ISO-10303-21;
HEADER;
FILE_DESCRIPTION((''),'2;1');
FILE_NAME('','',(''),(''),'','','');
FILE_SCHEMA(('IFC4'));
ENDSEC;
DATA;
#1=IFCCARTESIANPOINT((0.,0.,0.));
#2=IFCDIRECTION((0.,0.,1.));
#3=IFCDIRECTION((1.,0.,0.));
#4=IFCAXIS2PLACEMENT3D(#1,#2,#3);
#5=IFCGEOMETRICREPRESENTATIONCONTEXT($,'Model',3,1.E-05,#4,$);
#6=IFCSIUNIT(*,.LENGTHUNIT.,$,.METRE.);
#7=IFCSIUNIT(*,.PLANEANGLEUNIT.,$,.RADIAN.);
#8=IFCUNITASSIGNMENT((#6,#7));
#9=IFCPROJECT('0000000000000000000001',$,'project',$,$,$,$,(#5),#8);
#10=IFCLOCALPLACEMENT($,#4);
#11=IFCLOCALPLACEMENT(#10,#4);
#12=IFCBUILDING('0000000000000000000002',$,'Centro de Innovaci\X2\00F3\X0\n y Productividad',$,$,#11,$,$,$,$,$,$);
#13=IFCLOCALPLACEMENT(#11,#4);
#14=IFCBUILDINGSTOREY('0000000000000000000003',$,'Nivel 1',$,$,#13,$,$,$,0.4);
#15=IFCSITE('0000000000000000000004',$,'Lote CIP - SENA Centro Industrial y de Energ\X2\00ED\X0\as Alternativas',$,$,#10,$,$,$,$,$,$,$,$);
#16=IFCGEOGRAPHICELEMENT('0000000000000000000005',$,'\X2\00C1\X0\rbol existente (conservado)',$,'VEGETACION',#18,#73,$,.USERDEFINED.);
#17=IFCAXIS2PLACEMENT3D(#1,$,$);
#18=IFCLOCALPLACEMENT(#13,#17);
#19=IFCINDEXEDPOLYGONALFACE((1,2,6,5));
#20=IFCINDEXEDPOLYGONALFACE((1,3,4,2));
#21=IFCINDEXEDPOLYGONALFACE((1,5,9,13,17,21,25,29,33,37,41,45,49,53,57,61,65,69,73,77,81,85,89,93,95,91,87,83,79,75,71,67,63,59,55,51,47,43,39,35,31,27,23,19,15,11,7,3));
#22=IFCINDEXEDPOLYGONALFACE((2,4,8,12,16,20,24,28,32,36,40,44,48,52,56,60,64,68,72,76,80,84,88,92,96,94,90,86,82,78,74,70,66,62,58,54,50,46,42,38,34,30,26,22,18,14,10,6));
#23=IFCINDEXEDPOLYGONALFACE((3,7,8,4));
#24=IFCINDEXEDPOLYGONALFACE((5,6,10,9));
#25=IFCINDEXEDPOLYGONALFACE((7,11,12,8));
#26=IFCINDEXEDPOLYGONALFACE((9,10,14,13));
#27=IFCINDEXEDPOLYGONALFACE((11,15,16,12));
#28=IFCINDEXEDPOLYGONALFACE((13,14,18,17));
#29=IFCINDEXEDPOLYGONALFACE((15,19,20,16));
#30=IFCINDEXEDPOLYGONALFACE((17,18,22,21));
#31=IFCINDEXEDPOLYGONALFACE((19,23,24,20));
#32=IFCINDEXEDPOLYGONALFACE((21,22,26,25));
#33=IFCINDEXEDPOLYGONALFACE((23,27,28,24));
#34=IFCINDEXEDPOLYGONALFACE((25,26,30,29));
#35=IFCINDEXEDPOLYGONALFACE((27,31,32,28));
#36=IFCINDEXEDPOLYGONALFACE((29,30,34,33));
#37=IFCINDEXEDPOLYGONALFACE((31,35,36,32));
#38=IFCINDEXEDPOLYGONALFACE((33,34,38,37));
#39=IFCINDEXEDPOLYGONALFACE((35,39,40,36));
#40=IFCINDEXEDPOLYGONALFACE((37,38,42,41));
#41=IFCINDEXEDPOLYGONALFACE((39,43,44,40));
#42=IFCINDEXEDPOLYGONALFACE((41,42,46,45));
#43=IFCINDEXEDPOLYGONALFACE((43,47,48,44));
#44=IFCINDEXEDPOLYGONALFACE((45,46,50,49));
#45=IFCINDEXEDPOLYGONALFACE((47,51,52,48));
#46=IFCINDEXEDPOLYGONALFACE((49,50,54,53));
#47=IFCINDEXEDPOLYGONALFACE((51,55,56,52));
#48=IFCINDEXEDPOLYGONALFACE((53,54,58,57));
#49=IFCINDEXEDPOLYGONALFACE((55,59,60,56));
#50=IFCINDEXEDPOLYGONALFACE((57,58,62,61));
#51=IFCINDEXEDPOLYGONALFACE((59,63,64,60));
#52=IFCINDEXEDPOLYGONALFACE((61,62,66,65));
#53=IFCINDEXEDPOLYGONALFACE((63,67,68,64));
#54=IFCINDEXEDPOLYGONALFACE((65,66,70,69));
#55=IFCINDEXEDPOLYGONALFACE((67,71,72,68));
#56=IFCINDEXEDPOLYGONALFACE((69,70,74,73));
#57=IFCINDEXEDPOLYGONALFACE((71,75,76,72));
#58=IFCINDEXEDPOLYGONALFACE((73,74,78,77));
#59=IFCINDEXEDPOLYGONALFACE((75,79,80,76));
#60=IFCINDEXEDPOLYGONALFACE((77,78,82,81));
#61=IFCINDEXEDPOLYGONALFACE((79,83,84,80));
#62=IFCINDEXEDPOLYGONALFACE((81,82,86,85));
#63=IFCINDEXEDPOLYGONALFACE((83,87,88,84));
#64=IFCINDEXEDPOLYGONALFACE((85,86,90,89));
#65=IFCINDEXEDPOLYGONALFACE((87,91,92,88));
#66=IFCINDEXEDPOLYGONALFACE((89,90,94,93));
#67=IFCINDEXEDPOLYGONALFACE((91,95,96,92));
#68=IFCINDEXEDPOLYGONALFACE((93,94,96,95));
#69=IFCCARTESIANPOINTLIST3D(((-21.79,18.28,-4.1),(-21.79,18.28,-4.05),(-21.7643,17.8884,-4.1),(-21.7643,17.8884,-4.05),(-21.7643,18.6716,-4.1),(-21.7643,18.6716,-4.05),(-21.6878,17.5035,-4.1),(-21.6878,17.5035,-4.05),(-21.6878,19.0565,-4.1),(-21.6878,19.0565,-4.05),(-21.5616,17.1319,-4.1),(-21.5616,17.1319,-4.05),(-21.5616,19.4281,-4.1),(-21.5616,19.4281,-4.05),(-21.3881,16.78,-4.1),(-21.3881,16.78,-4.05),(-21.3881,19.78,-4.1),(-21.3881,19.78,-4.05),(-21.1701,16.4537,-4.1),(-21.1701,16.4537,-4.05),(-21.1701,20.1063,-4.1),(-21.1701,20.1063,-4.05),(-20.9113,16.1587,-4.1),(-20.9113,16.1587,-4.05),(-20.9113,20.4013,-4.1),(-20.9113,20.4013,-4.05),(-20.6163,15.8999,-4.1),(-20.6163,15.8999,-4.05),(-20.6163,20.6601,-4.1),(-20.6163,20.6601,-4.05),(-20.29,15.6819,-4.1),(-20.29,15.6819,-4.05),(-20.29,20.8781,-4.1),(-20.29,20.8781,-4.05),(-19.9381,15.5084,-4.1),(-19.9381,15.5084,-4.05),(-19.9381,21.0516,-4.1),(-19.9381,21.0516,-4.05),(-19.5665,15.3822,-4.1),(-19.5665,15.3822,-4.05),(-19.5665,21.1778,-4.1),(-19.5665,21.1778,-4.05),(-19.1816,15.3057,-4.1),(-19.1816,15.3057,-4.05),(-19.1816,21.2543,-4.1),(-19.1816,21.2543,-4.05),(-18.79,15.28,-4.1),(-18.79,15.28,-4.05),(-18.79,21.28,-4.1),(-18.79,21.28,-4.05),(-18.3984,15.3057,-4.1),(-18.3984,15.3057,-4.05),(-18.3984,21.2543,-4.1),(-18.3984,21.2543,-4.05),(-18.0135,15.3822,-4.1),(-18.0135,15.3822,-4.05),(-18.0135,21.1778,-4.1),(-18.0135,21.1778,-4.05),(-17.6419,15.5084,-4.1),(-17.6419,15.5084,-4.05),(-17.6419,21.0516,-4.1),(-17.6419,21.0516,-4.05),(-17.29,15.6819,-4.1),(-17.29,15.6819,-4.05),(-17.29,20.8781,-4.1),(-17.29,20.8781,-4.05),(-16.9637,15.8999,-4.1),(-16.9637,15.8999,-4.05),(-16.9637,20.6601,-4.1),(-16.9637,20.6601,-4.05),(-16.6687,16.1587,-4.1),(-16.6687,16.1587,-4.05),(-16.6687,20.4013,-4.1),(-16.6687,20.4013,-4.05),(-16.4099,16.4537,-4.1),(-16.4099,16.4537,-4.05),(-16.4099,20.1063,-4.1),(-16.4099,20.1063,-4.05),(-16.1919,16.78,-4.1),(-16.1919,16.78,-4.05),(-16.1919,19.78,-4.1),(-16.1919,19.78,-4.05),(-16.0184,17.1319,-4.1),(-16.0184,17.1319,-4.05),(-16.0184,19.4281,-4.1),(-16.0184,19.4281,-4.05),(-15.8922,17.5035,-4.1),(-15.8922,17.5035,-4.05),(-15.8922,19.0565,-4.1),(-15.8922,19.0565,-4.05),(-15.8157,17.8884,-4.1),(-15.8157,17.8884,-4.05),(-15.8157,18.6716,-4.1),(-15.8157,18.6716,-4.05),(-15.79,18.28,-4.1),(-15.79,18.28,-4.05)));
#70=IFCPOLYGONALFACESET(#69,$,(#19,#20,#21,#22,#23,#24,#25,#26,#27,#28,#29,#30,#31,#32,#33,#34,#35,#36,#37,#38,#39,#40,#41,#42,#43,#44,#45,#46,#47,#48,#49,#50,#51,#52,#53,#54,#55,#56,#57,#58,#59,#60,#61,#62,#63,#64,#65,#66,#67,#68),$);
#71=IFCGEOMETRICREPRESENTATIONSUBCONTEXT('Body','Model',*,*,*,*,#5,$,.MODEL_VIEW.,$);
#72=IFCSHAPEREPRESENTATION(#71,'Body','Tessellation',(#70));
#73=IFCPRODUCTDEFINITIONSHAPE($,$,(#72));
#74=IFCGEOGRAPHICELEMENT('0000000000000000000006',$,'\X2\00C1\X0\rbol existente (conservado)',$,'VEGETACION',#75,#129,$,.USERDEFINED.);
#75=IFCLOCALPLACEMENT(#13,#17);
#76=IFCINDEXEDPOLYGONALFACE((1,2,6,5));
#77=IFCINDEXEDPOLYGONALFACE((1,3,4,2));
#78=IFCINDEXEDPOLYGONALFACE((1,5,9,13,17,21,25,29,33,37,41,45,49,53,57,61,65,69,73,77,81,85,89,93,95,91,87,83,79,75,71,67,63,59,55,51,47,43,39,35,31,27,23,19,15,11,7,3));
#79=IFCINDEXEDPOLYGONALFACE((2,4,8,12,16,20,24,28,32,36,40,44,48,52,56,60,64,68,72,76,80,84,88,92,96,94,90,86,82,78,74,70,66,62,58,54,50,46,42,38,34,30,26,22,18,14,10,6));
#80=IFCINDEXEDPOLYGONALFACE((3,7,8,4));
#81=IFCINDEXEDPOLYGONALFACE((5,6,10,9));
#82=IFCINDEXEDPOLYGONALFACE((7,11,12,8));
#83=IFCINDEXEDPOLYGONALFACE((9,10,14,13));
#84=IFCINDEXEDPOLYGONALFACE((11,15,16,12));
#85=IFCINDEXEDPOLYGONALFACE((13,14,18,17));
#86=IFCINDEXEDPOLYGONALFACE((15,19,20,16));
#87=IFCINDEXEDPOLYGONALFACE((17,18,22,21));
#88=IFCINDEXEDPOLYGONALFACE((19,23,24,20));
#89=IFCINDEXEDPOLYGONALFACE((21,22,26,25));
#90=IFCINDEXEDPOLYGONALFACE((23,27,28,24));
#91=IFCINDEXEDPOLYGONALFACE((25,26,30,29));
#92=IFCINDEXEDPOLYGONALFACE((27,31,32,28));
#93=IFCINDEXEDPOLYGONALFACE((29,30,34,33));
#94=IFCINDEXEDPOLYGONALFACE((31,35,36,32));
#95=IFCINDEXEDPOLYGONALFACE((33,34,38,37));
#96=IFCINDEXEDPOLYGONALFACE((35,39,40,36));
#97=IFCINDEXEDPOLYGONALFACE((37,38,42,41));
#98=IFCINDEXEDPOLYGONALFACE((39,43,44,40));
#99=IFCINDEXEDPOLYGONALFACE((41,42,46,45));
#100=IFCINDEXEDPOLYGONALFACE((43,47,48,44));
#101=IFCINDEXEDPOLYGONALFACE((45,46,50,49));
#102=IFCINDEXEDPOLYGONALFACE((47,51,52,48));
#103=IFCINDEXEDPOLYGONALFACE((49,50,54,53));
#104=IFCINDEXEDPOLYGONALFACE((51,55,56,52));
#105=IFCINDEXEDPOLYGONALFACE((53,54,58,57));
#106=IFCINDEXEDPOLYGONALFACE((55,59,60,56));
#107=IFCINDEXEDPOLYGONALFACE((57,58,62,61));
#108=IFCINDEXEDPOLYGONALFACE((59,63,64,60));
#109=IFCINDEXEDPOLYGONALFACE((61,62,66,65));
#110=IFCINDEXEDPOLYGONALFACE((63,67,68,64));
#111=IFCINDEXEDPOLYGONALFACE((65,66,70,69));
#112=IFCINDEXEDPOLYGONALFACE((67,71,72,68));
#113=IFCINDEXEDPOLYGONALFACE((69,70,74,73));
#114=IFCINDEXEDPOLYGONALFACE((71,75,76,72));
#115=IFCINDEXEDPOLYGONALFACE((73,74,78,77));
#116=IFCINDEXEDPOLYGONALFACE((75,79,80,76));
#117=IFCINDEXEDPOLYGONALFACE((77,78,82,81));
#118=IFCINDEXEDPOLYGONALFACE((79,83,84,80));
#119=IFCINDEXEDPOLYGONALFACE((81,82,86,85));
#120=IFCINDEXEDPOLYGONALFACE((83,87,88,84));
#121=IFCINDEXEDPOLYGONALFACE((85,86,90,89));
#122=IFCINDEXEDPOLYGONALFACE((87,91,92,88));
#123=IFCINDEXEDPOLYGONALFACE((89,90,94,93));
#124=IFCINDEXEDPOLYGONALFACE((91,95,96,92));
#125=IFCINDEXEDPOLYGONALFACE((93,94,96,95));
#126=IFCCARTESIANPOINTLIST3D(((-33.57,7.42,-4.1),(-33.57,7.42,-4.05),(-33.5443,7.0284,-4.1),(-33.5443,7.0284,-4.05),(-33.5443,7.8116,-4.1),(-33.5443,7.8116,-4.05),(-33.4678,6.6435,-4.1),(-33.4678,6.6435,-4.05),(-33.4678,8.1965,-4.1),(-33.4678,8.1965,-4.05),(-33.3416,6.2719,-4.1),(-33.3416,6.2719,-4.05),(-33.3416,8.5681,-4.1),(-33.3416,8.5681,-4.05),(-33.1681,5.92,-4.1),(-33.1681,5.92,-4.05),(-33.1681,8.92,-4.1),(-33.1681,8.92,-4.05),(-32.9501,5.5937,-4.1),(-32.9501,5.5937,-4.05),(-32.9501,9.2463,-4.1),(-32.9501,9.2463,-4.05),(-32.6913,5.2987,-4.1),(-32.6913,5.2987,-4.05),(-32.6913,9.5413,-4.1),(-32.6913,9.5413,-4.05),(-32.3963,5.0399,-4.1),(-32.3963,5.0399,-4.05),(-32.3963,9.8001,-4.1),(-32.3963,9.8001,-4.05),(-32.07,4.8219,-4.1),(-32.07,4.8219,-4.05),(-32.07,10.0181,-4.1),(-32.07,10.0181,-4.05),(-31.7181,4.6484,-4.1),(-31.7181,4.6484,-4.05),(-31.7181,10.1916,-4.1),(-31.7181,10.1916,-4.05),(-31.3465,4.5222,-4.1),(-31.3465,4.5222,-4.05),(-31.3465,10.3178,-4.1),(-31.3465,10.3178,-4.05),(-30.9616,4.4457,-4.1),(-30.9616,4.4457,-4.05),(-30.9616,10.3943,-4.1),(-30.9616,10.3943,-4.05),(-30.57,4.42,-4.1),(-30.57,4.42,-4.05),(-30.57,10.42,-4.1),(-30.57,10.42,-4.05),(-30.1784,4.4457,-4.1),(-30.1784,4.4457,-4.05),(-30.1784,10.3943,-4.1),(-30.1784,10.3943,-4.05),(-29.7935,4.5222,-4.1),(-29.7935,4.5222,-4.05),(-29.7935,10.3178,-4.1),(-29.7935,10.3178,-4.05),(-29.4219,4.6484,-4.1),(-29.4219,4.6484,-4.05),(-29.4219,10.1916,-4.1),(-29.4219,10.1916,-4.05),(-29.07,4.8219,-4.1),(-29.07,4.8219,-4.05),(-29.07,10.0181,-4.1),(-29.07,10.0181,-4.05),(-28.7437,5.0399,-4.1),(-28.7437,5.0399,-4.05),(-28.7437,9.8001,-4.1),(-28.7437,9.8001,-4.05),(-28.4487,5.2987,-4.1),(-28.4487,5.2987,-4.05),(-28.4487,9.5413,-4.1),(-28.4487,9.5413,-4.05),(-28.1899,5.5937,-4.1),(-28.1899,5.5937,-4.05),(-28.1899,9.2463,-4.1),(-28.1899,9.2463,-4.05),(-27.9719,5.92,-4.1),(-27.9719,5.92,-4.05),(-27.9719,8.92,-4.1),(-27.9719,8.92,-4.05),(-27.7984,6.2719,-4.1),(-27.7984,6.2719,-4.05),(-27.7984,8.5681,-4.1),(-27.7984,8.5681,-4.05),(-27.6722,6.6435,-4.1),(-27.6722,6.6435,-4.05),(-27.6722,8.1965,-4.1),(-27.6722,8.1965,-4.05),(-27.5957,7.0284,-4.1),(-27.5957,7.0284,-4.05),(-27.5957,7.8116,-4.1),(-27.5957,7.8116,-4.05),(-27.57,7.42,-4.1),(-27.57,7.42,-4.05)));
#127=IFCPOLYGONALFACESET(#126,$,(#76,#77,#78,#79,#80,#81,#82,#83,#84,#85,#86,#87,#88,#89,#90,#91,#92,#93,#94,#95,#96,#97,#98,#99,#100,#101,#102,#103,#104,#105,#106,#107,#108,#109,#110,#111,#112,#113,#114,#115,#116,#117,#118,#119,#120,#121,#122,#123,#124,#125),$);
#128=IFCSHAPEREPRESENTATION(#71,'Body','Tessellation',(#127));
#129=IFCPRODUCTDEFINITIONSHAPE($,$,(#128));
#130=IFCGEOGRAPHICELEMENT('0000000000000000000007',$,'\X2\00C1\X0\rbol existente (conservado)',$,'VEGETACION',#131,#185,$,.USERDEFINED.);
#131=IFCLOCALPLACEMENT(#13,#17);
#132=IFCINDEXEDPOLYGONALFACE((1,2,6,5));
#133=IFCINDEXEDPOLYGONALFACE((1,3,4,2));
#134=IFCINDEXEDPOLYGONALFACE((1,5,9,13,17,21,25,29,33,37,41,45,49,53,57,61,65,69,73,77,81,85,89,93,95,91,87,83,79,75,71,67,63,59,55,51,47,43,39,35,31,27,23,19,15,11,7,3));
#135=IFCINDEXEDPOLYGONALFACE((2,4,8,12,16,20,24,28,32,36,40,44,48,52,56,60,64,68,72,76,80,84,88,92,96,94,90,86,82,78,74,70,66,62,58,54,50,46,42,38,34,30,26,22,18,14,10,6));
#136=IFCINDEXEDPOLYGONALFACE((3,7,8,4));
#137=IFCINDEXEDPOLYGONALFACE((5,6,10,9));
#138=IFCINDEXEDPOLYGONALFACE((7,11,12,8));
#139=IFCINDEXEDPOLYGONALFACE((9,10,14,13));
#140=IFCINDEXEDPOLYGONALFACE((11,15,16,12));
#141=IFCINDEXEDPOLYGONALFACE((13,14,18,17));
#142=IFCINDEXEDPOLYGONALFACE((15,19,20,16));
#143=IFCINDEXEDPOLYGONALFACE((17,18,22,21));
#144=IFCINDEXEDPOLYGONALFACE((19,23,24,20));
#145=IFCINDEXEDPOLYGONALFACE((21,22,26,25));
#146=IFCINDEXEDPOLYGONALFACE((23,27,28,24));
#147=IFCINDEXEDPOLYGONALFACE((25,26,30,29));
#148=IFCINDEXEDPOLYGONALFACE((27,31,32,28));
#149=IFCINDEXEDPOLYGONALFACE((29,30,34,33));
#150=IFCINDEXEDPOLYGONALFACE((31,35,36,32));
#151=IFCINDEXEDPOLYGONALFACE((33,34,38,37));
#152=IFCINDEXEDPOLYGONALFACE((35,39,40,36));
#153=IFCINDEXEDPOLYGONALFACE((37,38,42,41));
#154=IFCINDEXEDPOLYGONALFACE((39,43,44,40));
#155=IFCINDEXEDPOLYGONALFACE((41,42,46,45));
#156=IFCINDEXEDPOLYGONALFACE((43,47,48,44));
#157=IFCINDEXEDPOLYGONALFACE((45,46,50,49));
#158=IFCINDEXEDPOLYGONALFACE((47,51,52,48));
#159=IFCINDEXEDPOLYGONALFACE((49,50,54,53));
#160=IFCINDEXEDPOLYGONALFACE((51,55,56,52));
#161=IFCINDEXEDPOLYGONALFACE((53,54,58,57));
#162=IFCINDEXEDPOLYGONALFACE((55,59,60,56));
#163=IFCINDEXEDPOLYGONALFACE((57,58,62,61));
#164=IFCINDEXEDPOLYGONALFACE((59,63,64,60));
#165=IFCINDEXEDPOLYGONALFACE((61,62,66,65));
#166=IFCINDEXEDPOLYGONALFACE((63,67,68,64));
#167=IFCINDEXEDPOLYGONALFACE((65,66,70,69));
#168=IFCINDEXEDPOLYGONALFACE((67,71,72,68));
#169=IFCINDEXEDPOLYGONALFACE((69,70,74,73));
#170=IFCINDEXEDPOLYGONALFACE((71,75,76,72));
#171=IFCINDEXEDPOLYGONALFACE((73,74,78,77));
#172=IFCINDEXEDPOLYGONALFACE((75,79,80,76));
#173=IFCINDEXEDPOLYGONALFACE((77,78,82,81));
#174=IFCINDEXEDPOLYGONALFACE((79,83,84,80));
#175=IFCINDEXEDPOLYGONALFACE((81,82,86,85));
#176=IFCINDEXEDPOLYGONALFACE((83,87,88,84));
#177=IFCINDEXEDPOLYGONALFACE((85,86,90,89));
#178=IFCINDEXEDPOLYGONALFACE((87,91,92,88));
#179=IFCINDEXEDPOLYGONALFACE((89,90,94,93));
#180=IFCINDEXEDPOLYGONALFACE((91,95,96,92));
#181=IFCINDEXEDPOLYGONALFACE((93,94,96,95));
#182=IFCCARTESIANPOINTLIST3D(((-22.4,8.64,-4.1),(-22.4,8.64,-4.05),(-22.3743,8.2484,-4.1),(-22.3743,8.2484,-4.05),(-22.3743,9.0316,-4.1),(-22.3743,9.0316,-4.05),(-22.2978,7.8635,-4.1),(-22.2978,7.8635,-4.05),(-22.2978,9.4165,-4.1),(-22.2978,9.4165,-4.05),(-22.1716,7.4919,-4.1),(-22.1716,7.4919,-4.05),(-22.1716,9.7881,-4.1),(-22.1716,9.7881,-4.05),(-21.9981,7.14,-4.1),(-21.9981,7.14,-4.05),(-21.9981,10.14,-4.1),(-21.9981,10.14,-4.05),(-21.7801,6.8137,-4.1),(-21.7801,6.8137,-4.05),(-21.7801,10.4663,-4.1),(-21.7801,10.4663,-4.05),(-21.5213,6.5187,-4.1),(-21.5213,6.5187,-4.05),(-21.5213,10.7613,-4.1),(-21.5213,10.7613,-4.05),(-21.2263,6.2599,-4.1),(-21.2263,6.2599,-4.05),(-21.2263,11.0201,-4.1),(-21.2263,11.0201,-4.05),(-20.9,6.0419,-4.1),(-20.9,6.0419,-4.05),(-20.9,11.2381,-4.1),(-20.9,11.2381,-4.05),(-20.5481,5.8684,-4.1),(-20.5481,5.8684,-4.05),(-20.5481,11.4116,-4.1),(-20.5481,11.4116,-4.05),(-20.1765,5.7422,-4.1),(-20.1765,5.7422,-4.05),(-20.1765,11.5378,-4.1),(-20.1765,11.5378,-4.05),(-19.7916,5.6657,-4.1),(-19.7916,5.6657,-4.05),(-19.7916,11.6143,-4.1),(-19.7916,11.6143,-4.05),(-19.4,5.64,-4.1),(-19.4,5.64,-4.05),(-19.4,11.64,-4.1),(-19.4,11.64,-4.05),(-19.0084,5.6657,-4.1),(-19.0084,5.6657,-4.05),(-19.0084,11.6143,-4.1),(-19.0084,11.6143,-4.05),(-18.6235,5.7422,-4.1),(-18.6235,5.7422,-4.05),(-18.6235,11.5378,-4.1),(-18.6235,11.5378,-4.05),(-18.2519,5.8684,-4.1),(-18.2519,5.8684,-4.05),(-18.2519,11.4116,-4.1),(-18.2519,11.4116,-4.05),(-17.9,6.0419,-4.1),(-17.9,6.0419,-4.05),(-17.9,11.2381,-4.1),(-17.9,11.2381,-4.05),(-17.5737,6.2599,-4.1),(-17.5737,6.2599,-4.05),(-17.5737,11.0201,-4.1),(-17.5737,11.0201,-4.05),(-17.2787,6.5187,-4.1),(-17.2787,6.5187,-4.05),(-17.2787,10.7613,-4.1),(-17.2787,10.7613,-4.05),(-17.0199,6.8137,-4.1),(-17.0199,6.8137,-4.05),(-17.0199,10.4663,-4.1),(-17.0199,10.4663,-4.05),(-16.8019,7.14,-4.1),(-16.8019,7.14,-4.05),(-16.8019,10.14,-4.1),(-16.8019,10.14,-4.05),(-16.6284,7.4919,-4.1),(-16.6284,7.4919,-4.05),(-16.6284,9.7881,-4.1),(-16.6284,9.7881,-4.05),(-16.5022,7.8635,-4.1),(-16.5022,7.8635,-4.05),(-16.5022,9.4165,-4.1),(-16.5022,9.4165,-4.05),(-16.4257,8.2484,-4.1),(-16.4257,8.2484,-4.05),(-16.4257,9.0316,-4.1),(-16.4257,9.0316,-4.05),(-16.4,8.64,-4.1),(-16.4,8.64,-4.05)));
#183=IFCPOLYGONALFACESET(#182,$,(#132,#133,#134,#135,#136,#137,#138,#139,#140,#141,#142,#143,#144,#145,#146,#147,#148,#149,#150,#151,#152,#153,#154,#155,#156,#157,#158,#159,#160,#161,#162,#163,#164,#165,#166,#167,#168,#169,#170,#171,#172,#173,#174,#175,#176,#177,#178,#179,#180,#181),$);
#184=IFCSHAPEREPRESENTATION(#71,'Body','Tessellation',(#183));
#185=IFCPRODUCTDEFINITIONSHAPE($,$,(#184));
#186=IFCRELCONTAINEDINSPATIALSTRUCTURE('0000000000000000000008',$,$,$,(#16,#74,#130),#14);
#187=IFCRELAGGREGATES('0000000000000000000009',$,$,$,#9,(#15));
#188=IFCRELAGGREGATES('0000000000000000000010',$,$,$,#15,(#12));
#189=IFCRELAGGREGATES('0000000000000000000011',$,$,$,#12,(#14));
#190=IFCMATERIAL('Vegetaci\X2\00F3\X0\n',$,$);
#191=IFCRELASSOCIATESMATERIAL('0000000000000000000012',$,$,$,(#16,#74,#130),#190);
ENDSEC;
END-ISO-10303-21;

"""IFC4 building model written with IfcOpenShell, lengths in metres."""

from ifc_helpers import new_model, si_unit, frame, origin_with_axes, place, context, subcontext, project, spatial, polyline, outline, extrude, material, element, save


model = new_model("IFC4")

# Units and contexts
model_context = context("Model", 3, precision=1e-05, world=origin_with_axes())
body_context = subcontext(model_context, "Body", "Model", "MODEL_VIEW")
ifc_project = project(units=[si_unit("LENGTHUNIT", "METRE"), si_unit("PLANEANGLEUNIT", "RADIAN")], contexts=[model_context])

# Site, building, storey
site_placement = place(None, origin_with_axes())
site = spatial("IfcSite", under=ifc_project, at=site_placement, Name="Lote CIP - SENA Centro Industrial y de Energías Alternativas")
building_placement = place(site_placement, origin_with_axes())
building = spatial("IfcBuilding", under=site, at=building_placement, Name="Centro de Innovación y Productividad")
storey_placement = place(building_placement, origin_with_axes())
storey = spatial("IfcBuildingStorey", under=building, at=storey_placement, Name="Nivel 1", Elevation=0.4)

# Geographic elements
ifc_material_1 = material(Name="Vegetación")
geographic_element_1_placement = place(storey_placement, origin_with_axes())
element("IfcGeographicElement", 1, at=geographic_element_1_placement, inside=storey, material=ifc_material_1, Name="Árbol existente (conservado)", ObjectType="VEGETACION", PredefinedType="USERDEFINED", context=body_context, shape_type="SweptSolid", body=[
    extrude(outline(polyline([(-15.79, 18.28), (-15.8157, 17.8884), (-15.8922, 17.5035), (-16.0184, 17.1319), (-16.1919, 16.78), (-16.4099, 16.4537), (-16.6687, 16.1587), (-16.9637, 15.8999), (-17.29, 15.6819), (-17.6419, 15.5084), (-18.0135, 15.3822), (-18.3984, 15.3057), (-18.79, 15.28), (-19.1816, 15.3057), (-19.5665, 15.3822), (-19.9381, 15.5084), (-20.29, 15.6819), (-20.6163, 15.8999), (-20.9113, 16.1587), (-21.1701, 16.4537), (-21.3881, 16.78), (-21.5616, 17.1319), (-21.6878, 17.5035), (-21.7643, 17.8884), (-21.79, 18.28), (-21.7643, 18.6716), (-21.6878, 19.0565), (-21.5616, 19.4281), (-21.3881, 19.78), (-21.1701, 20.1063), (-20.9113, 20.4013), (-20.6163, 20.6601), (-20.29, 20.8781), (-19.9381, 21.0516), (-19.5665, 21.1778), (-19.1816, 21.2543), (-18.79, 21.28), (-18.3984, 21.2543), (-18.0135, 21.1778), (-17.6419, 21.0516), (-17.29, 20.8781), (-16.9637, 20.6601), (-16.6687, 20.4013), (-16.4099, 20.1063), (-16.1919, 19.78), (-16.0184, 19.4281), (-15.8922, 19.0565), (-15.8157, 18.6716), (-15.79, 18.28)])), frame((0.0, 0.0, -4.1)), (0.0, 0.0, 1.0), 0.05),
])
geographic_element_2_placement = place(storey_placement, origin_with_axes())
element("IfcGeographicElement", 2, at=geographic_element_2_placement, inside=storey, material=ifc_material_1, Name="Árbol existente (conservado)", ObjectType="VEGETACION", PredefinedType="USERDEFINED", context=body_context, shape_type="SweptSolid", body=[
    extrude(outline(polyline([(-27.57, 7.42), (-27.5957, 7.0284), (-27.6722, 6.6435), (-27.7984, 6.2719), (-27.9719, 5.92), (-28.1899, 5.5937), (-28.4487, 5.2987), (-28.7437, 5.0399), (-29.07, 4.8219), (-29.4219, 4.6484), (-29.7935, 4.5222), (-30.1784, 4.4457), (-30.57, 4.42), (-30.9616, 4.4457), (-31.3465, 4.5222), (-31.7181, 4.6484), (-32.07, 4.8219), (-32.3963, 5.0399), (-32.6913, 5.2987), (-32.9501, 5.5937), (-33.1681, 5.92), (-33.3416, 6.2719), (-33.4678, 6.6435), (-33.5443, 7.0284), (-33.57, 7.42), (-33.5443, 7.8116), (-33.4678, 8.1965), (-33.3416, 8.5681), (-33.1681, 8.92), (-32.9501, 9.2463), (-32.6913, 9.5413), (-32.3963, 9.8001), (-32.07, 10.0181), (-31.7181, 10.1916), (-31.3465, 10.3178), (-30.9616, 10.3943), (-30.57, 10.42), (-30.1784, 10.3943), (-29.7935, 10.3178), (-29.4219, 10.1916), (-29.07, 10.0181), (-28.7437, 9.8001), (-28.4487, 9.5413), (-28.1899, 9.2463), (-27.9719, 8.92), (-27.7984, 8.5681), (-27.6722, 8.1965), (-27.5957, 7.8116), (-27.57, 7.42)])), frame((0.0, 0.0, -4.1)), (0.0, 0.0, 1.0), 0.05),
])
geographic_element_3_placement = place(storey_placement, origin_with_axes())
element("IfcGeographicElement", 3, at=geographic_element_3_placement, inside=storey, material=ifc_material_1, Name="Árbol existente (conservado)", ObjectType="VEGETACION", PredefinedType="USERDEFINED", context=body_context, shape_type="SweptSolid", body=[
    extrude(outline(polyline([(-16.4, 8.64), (-16.4257, 8.2484), (-16.5022, 7.8635), (-16.6284, 7.4919), (-16.8019, 7.14), (-17.0199, 6.8137), (-17.2787, 6.5187), (-17.5737, 6.2599), (-17.9, 6.0419), (-18.2519, 5.8684), (-18.6235, 5.7422), (-19.0084, 5.6657), (-19.4, 5.64), (-19.7916, 5.6657), (-20.1765, 5.7422), (-20.5481, 5.8684), (-20.9, 6.0419), (-21.2263, 6.2599), (-21.5213, 6.5187), (-21.7801, 6.8137), (-21.9981, 7.14), (-22.1716, 7.4919), (-22.2978, 7.8635), (-22.3743, 8.2484), (-22.4, 8.64), (-22.3743, 9.0316), (-22.2978, 9.4165), (-22.1716, 9.7881), (-21.9981, 10.14), (-21.7801, 10.4663), (-21.5213, 10.7613), (-21.2263, 11.0201), (-20.9, 11.2381), (-20.5481, 11.4116), (-20.1765, 11.5378), (-19.7916, 11.6143), (-19.4, 11.64), (-19.0084, 11.6143), (-18.6235, 11.5378), (-18.2519, 11.4116), (-17.9, 11.2381), (-17.5737, 11.0201), (-17.2787, 10.7613), (-17.0199, 10.4663), (-16.8019, 10.14), (-16.6284, 9.7881), (-16.5022, 9.4165), (-16.4257, 9.0316), (-16.4, 8.64)])), frame((0.0, 0.0, -4.1)), (0.0, 0.0, 1.0), 0.05),
])

save(model, "model.ifc")
